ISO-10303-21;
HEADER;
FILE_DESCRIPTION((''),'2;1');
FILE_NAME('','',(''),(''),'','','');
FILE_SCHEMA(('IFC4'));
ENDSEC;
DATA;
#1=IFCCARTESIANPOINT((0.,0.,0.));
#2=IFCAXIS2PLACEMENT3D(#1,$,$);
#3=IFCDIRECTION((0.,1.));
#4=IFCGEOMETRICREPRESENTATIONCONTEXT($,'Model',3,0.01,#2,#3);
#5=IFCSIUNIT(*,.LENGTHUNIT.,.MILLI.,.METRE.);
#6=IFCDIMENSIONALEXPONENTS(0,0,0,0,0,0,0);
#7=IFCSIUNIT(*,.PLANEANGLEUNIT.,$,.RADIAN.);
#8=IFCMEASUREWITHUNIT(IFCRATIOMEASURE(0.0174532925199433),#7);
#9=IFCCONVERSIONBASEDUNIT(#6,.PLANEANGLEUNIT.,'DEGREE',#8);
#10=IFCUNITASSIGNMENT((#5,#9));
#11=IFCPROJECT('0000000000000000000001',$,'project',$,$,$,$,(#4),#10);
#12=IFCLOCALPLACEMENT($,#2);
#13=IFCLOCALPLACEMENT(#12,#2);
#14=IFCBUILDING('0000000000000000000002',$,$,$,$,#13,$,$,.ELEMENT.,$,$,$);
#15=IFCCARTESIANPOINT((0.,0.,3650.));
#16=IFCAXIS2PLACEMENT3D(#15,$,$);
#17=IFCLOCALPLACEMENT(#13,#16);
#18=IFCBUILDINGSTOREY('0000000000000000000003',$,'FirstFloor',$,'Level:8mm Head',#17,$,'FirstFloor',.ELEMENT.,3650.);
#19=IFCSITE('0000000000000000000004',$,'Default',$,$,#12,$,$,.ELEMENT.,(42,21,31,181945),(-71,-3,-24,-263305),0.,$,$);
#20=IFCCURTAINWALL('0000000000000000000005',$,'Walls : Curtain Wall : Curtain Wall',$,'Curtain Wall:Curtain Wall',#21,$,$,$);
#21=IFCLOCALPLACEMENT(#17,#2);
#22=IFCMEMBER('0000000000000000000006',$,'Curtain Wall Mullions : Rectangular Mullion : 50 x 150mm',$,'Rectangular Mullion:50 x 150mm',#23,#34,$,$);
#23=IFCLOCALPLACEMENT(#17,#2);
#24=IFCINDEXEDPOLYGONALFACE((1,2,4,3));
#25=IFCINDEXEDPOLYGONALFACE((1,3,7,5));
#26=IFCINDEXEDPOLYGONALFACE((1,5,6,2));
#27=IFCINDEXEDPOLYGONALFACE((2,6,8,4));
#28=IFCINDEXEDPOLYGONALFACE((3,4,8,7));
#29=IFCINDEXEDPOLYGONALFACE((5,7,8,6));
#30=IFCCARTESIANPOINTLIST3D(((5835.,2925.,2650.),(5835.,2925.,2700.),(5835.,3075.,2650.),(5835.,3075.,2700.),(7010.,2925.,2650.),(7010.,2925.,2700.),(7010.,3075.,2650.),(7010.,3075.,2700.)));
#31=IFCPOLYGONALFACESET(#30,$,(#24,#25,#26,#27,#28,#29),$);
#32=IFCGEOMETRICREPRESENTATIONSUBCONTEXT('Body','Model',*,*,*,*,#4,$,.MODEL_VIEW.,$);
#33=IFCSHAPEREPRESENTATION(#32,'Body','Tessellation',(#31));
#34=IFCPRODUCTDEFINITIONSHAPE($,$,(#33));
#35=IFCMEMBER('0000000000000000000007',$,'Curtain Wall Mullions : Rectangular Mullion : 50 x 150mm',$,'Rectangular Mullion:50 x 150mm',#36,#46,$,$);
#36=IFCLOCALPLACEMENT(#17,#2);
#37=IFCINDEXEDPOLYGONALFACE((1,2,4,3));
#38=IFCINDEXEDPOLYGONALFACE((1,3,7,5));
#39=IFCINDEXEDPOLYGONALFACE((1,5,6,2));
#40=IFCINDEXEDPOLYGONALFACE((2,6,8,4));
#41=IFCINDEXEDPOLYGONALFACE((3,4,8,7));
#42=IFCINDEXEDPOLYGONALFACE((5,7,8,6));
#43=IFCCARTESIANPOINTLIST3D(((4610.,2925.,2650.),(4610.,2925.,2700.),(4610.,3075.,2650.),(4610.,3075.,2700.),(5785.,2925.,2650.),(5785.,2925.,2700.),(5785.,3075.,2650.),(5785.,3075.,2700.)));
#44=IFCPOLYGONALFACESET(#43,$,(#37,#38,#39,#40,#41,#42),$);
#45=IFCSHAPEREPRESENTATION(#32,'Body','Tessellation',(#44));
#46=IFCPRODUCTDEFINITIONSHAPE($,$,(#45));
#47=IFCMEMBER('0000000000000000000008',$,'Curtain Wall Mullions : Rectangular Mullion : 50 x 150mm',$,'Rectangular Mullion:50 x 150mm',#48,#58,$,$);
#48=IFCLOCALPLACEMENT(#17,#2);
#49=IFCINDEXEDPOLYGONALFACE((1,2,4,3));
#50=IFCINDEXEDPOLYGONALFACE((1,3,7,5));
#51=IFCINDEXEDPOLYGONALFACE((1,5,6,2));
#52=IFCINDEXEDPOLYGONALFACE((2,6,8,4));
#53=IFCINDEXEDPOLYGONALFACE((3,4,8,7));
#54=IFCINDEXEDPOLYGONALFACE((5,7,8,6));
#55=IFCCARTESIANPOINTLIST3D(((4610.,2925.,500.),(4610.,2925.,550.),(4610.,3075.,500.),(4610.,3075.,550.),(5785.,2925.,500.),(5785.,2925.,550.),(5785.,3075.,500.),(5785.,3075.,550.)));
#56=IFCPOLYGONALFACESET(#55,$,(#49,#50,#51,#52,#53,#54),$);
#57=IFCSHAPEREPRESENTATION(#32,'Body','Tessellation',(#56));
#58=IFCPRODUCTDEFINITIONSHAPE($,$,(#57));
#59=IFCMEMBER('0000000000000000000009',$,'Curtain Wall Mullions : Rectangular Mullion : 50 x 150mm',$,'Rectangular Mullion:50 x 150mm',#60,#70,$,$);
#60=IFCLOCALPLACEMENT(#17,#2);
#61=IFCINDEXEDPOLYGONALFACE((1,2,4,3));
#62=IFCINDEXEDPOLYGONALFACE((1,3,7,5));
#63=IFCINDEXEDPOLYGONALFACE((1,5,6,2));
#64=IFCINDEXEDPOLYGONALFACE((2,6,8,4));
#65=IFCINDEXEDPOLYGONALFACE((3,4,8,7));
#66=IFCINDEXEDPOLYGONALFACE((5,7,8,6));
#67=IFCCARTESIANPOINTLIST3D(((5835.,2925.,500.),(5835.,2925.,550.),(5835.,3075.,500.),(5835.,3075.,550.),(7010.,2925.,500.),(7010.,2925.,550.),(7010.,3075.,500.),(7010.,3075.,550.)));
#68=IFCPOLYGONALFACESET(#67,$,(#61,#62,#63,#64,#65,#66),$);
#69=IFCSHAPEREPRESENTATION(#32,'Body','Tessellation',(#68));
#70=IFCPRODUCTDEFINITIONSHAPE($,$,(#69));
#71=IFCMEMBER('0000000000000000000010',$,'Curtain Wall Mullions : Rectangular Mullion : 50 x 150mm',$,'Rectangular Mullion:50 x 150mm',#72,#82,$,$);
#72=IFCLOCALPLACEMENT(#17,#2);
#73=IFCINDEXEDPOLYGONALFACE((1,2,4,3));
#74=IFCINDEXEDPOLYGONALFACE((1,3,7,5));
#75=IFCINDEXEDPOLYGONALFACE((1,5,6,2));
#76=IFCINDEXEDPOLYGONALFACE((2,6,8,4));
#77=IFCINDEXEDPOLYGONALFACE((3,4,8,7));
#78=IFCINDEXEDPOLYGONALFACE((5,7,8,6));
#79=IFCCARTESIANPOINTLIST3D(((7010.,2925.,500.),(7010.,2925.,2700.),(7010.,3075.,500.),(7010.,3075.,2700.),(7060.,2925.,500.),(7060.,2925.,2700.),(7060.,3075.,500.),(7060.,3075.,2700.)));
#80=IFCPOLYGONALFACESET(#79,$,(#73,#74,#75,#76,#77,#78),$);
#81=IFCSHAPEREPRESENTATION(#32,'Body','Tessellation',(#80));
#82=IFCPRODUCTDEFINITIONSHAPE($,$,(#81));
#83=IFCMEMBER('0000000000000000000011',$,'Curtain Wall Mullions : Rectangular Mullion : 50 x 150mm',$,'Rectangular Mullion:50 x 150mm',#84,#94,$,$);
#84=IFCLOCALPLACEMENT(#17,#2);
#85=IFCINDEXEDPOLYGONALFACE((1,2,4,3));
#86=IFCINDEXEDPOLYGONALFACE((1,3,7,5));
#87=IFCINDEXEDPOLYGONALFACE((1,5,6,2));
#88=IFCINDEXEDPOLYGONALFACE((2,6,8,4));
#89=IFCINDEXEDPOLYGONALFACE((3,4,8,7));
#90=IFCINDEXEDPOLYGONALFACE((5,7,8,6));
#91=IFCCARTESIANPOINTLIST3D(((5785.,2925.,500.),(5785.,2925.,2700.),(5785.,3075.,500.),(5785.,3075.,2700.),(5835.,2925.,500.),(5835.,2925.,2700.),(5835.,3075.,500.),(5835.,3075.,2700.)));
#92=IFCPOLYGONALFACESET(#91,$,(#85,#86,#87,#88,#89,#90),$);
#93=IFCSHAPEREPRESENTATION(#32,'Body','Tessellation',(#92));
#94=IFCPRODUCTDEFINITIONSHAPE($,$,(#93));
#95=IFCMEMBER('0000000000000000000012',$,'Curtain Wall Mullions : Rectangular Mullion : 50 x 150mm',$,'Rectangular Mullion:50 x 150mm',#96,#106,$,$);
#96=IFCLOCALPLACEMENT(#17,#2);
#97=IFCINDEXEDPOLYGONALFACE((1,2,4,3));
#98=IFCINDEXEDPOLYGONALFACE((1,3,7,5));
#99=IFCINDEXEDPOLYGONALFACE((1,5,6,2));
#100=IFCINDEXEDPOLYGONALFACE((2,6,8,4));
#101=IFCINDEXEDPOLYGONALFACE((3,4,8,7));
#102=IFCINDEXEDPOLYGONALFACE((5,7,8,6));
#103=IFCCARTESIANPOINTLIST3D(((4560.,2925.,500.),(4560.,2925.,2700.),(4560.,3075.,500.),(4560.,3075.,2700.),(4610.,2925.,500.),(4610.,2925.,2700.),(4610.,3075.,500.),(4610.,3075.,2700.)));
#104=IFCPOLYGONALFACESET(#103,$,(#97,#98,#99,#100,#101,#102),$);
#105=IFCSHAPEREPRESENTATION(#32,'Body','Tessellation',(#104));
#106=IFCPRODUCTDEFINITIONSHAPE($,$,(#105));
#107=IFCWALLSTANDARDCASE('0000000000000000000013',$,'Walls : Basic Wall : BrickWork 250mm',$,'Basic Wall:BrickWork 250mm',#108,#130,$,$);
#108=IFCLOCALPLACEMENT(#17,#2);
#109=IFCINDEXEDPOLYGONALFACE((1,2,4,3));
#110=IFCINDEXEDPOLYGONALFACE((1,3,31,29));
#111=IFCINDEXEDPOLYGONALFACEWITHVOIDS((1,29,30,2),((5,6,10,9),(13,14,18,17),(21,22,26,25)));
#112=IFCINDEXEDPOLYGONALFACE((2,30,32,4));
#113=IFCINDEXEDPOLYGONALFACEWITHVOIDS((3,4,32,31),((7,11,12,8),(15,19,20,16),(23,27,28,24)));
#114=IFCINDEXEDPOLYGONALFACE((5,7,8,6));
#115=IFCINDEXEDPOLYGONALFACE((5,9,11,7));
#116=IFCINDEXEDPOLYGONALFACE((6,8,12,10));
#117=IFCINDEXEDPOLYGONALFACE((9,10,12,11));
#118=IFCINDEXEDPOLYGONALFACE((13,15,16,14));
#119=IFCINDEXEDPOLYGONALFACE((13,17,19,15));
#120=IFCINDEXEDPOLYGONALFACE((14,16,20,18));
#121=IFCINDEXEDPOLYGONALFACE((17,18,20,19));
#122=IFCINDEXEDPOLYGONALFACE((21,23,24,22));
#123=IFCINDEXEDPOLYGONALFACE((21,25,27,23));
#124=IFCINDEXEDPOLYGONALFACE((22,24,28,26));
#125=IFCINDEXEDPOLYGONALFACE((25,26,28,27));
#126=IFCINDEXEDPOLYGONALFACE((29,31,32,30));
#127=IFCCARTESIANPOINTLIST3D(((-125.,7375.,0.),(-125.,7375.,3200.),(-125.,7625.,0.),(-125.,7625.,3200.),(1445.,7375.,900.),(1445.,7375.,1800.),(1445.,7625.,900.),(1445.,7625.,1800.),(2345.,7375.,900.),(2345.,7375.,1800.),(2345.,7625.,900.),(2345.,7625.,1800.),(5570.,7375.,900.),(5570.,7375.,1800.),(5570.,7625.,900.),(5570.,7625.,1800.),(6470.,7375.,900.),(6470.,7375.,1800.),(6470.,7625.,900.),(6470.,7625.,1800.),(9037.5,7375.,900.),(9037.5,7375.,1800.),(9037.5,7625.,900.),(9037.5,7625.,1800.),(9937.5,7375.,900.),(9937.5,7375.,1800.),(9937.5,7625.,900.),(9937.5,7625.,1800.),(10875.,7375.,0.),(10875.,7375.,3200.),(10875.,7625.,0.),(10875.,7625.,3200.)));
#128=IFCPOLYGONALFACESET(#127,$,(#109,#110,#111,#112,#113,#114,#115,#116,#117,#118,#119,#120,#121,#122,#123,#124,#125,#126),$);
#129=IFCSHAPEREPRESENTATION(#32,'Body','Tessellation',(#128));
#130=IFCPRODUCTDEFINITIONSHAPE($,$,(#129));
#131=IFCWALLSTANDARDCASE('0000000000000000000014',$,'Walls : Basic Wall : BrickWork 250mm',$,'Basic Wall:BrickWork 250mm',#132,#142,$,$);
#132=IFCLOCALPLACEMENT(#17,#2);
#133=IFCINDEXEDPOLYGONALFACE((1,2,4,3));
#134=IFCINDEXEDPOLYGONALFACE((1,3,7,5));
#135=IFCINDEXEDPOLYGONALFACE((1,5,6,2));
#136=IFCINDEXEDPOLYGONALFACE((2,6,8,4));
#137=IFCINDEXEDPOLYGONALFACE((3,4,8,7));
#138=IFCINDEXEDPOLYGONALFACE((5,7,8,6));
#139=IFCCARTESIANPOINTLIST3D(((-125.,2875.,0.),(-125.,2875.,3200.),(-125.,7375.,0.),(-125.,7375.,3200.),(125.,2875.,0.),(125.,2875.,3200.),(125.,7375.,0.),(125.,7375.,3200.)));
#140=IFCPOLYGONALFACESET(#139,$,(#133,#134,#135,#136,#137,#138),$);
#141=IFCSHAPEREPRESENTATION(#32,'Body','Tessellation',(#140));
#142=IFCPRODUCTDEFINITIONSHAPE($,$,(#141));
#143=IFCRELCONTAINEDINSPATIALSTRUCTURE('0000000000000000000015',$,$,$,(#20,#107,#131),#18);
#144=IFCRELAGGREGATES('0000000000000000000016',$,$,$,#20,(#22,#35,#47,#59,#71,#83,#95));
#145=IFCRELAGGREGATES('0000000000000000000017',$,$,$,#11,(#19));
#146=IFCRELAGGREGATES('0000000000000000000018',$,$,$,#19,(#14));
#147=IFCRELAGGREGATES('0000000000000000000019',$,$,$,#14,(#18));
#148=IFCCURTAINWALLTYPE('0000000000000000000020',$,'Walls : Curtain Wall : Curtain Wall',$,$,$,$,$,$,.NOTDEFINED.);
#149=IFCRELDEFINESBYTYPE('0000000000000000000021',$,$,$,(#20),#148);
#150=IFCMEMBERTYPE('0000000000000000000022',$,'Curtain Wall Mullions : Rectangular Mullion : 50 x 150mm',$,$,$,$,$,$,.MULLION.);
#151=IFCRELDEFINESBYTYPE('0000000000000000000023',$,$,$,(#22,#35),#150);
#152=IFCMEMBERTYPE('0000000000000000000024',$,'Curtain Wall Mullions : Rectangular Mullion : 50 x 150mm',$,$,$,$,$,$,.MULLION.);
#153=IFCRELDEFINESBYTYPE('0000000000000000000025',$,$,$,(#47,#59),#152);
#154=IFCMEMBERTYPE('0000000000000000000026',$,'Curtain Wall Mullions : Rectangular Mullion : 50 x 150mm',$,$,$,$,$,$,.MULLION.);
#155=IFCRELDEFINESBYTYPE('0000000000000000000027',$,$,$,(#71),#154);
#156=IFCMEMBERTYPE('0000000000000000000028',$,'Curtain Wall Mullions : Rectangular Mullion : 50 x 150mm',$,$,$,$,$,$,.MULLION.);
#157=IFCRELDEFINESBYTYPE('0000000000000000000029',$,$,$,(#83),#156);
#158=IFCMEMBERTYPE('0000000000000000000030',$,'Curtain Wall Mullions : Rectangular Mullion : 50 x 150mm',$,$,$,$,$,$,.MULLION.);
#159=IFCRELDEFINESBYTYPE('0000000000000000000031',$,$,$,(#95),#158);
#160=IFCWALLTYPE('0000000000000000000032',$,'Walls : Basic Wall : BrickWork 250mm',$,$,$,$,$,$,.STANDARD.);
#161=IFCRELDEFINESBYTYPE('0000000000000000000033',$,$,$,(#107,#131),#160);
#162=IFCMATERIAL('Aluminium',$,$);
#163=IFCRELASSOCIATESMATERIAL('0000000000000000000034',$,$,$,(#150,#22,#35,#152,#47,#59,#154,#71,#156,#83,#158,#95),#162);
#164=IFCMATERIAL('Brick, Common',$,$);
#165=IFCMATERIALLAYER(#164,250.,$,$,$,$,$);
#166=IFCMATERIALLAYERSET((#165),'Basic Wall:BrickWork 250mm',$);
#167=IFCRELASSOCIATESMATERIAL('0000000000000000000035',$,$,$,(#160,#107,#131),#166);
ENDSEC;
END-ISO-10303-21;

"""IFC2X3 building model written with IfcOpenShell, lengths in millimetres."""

from ifc_helpers import new_model, entity, si_unit, converted_unit, direction, frame, frame_2d, origin, origin_2d_with_axis, place, context, subcontext, project, spatial, rectangle, extrude, clip, halfspace, source, transform, mapped, material, layer, layer_set, layer_usage, type_object, type_shapes, element, aggregate, save


model = new_model("IFC2X3")

# Units and contexts
model_context = context("Model", 3, precision=0.01, world=origin(), true_north=direction((0.0, 1.0)))
body_context = subcontext(model_context, "Body", "Model", "MODEL_VIEW")
ifc_project = project(units=[si_unit("LENGTHUNIT", "METRE", prefix="MILLI"), converted_unit("PLANEANGLEUNIT", "DEGREE", entity("IfcRatioMeasure", 0.0174532925199433), si_unit("PLANEANGLEUNIT", "RADIAN"), dimensions=[0, 0, 0, 0, 0, 0, 0])], contexts=[model_context])

# Site, building, storey
site_placement = place(None, origin())
site = spatial("IfcSite", under=ifc_project, at=site_placement, Name="Default", CompositionType="ELEMENT", RefLatitude=(42, 21, 31, 181945), RefLongitude=(-71, -3, -24, -263305), RefElevation=0.0)
building_placement = place(site_placement, origin())
building = spatial("IfcBuilding", under=site, at=building_placement, CompositionType="ELEMENT")
storey_placement = place(building_placement, frame((0.0, 0.0, 3650.0)))
storey = spatial("IfcBuildingStorey", under=building, at=storey_placement, Name="FirstFloor", ObjectType="Level:8mm Head", LongName="FirstFloor", CompositionType="ELEMENT", Elevation=3650.0)

# Curtain wall, members
curtain_wall_type = type_object("IfcCurtainWallType", Name="Walls : Curtain Wall : Curtain Wall", PredefinedType="NOTDEFINED")
curtain_wall_placement = place(storey_placement, frame((0.0, 0.0, -3650.0)))
curtain_wall = element("IfcCurtainWall", 1, at=curtain_wall_placement, inside=storey, type_object=curtain_wall_type, Name="Walls : Curtain Wall : Curtain Wall", ObjectType="Curtain Wall:Curtain Wall")
ifc_material_1 = material(Name="Aluminium")
member_type_1 = type_object("IfcMemberType", Name="Curtain Wall Mullions : Rectangular Mullion : 50 x 150mm", PredefinedType="MULLION", material=ifc_material_1)
shared_shape_1 = source(origin(), body_context, "Body", "SweptSolid", [
    extrude(rectangle(XDim=150.0, YDim=50.0, at=origin_2d_with_axis()), frame((-25.0, 0.0, -1175.0), z_axis=(0.0, 0.0, 1.0), x_axis=(0.0, -1.0, 0.0)), (0.0, 0.0, 1.0), 1175.0),
])
type_shapes(member_type_1, [shared_shape_1])
member_1_placement = place(storey_placement, frame((7010.0, 3000.0, 2700.0), z_axis=(1.0, 0.0, 0.0), x_axis=(0.0, 0.0, 1.0)))
member_1 = element("IfcMember", 2, at=member_1_placement, type_object=member_type_1, material=ifc_material_1, Name="Curtain Wall Mullions : Rectangular Mullion : 50 x 150mm", ObjectType="Rectangular Mullion:50 x 150mm", context=body_context, shape_type="MappedRepresentation", body=[
    mapped(shared_shape_1, transform((0.0, 0.0, 0.0), scale=1.0)),
])
member_2_placement = place(storey_placement, frame((5785.0, 3000.0, 2700.0), z_axis=(1.0, 0.0, 0.0), x_axis=(0.0, 0.0, 1.0)))
member_2 = element("IfcMember", 3, at=member_2_placement, type_object=member_type_1, material=ifc_material_1, Name="Curtain Wall Mullions : Rectangular Mullion : 50 x 150mm", ObjectType="Rectangular Mullion:50 x 150mm", context=body_context, shape_type="MappedRepresentation", body=[
    mapped(shared_shape_1, transform((0.0, 0.0, 0.0), scale=1.0)),
])
member_type_2 = type_object("IfcMemberType", Name="Curtain Wall Mullions : Rectangular Mullion : 50 x 150mm", PredefinedType="MULLION", material=ifc_material_1)
shared_shape_2 = source(origin(), body_context, "Body", "SweptSolid", [
    extrude(rectangle(XDim=150.0, YDim=50.0, at=origin_2d_with_axis()), frame((-25.0, 0.0, -1175.0), z_axis=(0.0, 0.0, 1.0), x_axis=(0.0, -1.0, 0.0)), (0.0, 0.0, 1.0), 1175.0),
])
type_shapes(member_type_2, [shared_shape_2])
member_3_placement = place(storey_placement, frame((4610.0, 3000.0, 500.0), z_axis=(-1.0, 0.0, 0.0), x_axis=(0.0, 0.0, -1.0)))
member_3 = element("IfcMember", 4, at=member_3_placement, type_object=member_type_2, material=ifc_material_1, Name="Curtain Wall Mullions : Rectangular Mullion : 50 x 150mm", ObjectType="Rectangular Mullion:50 x 150mm", context=body_context, shape_type="MappedRepresentation", body=[
    mapped(shared_shape_2, transform((0.0, 0.0, 0.0), scale=1.0)),
])
member_4_placement = place(storey_placement, frame((5835.0, 3000.0, 500.0), z_axis=(-1.0, 0.0, 0.0), x_axis=(0.0, 0.0, -1.0)))
member_4 = element("IfcMember", 5, at=member_4_placement, type_object=member_type_2, material=ifc_material_1, Name="Curtain Wall Mullions : Rectangular Mullion : 50 x 150mm", ObjectType="Rectangular Mullion:50 x 150mm", context=body_context, shape_type="MappedRepresentation", body=[
    mapped(shared_shape_2, transform((0.0, 0.0, 0.0), scale=1.0)),
])
member_type_3 = type_object("IfcMemberType", Name="Curtain Wall Mullions : Rectangular Mullion : 50 x 150mm", PredefinedType="MULLION", material=ifc_material_1)
shared_shape_3 = source(origin(), body_context, "Body", "SweptSolid", [
    extrude(rectangle(XDim=150.0, YDim=50.0, at=origin_2d_with_axis()), frame((-25.0, 0.0, -2200.0), z_axis=(0.0, 0.0, 1.0), x_axis=(0.0, -1.0, 0.0)), (0.0, 0.0, 1.0), 2200.0),
])
type_shapes(member_type_3, [shared_shape_3])
member_5_placement = place(storey_placement, frame((7060.0, 3000.0, 500.0), z_axis=(0.0, 0.0, -1.0), x_axis=(1.0, 0.0, 0.0)))
member_5 = element("IfcMember", 6, at=member_5_placement, type_object=member_type_3, material=ifc_material_1, Name="Curtain Wall Mullions : Rectangular Mullion : 50 x 150mm", ObjectType="Rectangular Mullion:50 x 150mm", context=body_context, shape_type="MappedRepresentation", body=[
    mapped(shared_shape_3, transform((0.0, 0.0, 0.0), scale=1.0)),
])
member_type_4 = type_object("IfcMemberType", Name="Curtain Wall Mullions : Rectangular Mullion : 50 x 150mm", PredefinedType="MULLION", material=ifc_material_1)
shared_shape_4 = source(origin(), body_context, "Body", "SweptSolid", [
    extrude(rectangle(XDim=150.0, YDim=50.0, at=origin_2d_with_axis()), frame((0.0, 0.0, -2200.0), z_axis=(0.0, 0.0, 1.0), x_axis=(0.0, -1.0, 0.0)), (0.0, 0.0, 1.0), 2200.0),
])
type_shapes(member_type_4, [shared_shape_4])
member_6_placement = place(storey_placement, frame((5810.0, 3000.0, 500.0), z_axis=(0.0, 0.0, -1.0), x_axis=(1.0, 0.0, 0.0)))
member_6 = element("IfcMember", 7, at=member_6_placement, type_object=member_type_4, material=ifc_material_1, Name="Curtain Wall Mullions : Rectangular Mullion : 50 x 150mm", ObjectType="Rectangular Mullion:50 x 150mm", context=body_context, shape_type="MappedRepresentation", body=[
    mapped(shared_shape_4, transform((0.0, 0.0, 0.0), scale=1.0)),
])
member_type_5 = type_object("IfcMemberType", Name="Curtain Wall Mullions : Rectangular Mullion : 50 x 150mm", PredefinedType="MULLION", material=ifc_material_1)
shared_shape_5 = source(origin(), body_context, "Body", "SweptSolid", [
    extrude(rectangle(XDim=150.0, YDim=50.0, at=origin_2d_with_axis()), frame((-25.0, 0.0, -2200.0), z_axis=(0.0, 0.0, 1.0), x_axis=(0.0, -1.0, 0.0)), (0.0, 0.0, 1.0), 2200.0),
])
type_shapes(member_type_5, [shared_shape_5])
member_7_placement = place(storey_placement, frame((4560.0, 3000.0, 2700.0), z_axis=(0.0, 0.0, 1.0), x_axis=(-1.0, 0.0, 0.0)))
member_7 = element("IfcMember", 8, at=member_7_placement, type_object=member_type_5, material=ifc_material_1, Name="Curtain Wall Mullions : Rectangular Mullion : 50 x 150mm", ObjectType="Rectangular Mullion:50 x 150mm", context=body_context, shape_type="MappedRepresentation", body=[
    mapped(shared_shape_5, transform((0.0, 0.0, 0.0), scale=1.0)),
])
aggregate(curtain_wall, [member_1, member_2, member_3, member_4, member_5, member_6, member_7])

# Wall, openings
ifc_material_2 = material(Name="Brick, Common")
ifc_layer = layer(ifc_material_2, 250.0)
ifc_layer_set = layer_set([ifc_layer], Name="Basic Wall:BrickWork 250mm")
ifc_layer_usage_1 = layer_usage(ifc_layer_set, "AXIS2", "POSITIVE", -125.0)
wall_type = type_object("IfcWallType", Name="Walls : Basic Wall : BrickWork 250mm", PredefinedType="STANDARD", material=ifc_layer_set)
wall_1_placement = place(storey_placement, frame((-125.0, 7500.0, 0.0)))
wall_1 = element("IfcWallStandardCase", 9, at=wall_1_placement, inside=storey, type_object=wall_type, material=ifc_layer_usage_1, Name="Walls : Basic Wall : BrickWork 250mm", ObjectType="Basic Wall:BrickWork 250mm", context=body_context, shape_type="Clipping", body=[
    clip(extrude(rectangle(XDim=11000.0, YDim=250.0, at=frame_2d((5500.0, 0.0), x_axis=(-1.0, 0.0))), origin(), (0.0, 0.0, 1.0), 3200.0), halfspace(frame((0.0, 0.0, -3200.0)), True)),
])
opening_1_placement = place(wall_1_placement, frame((2470.0, 125.0, 900.0)))
element("IfcOpeningElement", 10, at=opening_1_placement, cuts=wall_1, ObjectType="Opening", context=body_context, shape_type="SweptSolid", body=[
    extrude(rectangle(XDim=900.0, YDim=900.0, at=frame_2d((450.0, 450.0), x_axis=(-1.0, 0.0))), frame((0.0, 0.0, 0.0), z_axis=(0.0, -1.0, 0.0), x_axis=(0.0, 0.0, 1.0)), (0.0, 0.0, 1.0), 250.0),
])
opening_2_placement = place(wall_1_placement, frame((6595.0, 125.0, 900.0)))
element("IfcOpeningElement", 11, at=opening_2_placement, cuts=wall_1, ObjectType="Opening", context=body_context, shape_type="SweptSolid", body=[
    extrude(rectangle(XDim=900.0, YDim=900.0, at=frame_2d((450.0, 450.0), x_axis=(-1.0, 0.0))), frame((0.0, 0.0, 0.0), z_axis=(0.0, -1.0, 0.0), x_axis=(0.0, 0.0, 1.0)), (0.0, 0.0, 1.0), 250.0),
])
opening_3_placement = place(wall_1_placement, frame((10062.5, 125.0, 900.0)))
element("IfcOpeningElement", 12, at=opening_3_placement, cuts=wall_1, ObjectType="Opening", context=body_context, shape_type="SweptSolid", body=[
    extrude(rectangle(XDim=900.0, YDim=900.0, at=frame_2d((450.0, 450.0), x_axis=(-1.0, 0.0))), frame((0.0, 0.0, 0.0), z_axis=(0.0, -1.0, 0.0), x_axis=(0.0, 0.0, 1.0)), (0.0, 0.0, 1.0), 250.0),
])

# Wall
ifc_layer_usage_2 = layer_usage(ifc_layer_set, "AXIS2", "POSITIVE", -125.0)
wall_2_placement = place(storey_placement, frame((0.0, 7375.0, 0.0), z_axis=(0.0, 0.0, 1.0), x_axis=(0.0, -1.0, 0.0)))
element("IfcWallStandardCase", 13, at=wall_2_placement, inside=storey, type_object=wall_type, material=ifc_layer_usage_2, Name="Walls : Basic Wall : BrickWork 250mm", ObjectType="Basic Wall:BrickWork 250mm", context=body_context, shape_type="Clipping", body=[
    clip(extrude(rectangle(XDim=4500.0, YDim=250.0, at=frame_2d((2250.0, 0.0), x_axis=(-1.0, 0.0))), origin(), (0.0, 0.0, 1.0), 3200.0), halfspace(frame((0.0, 0.0, -3200.0)), True)),
])

save(model, "model.ifc")
